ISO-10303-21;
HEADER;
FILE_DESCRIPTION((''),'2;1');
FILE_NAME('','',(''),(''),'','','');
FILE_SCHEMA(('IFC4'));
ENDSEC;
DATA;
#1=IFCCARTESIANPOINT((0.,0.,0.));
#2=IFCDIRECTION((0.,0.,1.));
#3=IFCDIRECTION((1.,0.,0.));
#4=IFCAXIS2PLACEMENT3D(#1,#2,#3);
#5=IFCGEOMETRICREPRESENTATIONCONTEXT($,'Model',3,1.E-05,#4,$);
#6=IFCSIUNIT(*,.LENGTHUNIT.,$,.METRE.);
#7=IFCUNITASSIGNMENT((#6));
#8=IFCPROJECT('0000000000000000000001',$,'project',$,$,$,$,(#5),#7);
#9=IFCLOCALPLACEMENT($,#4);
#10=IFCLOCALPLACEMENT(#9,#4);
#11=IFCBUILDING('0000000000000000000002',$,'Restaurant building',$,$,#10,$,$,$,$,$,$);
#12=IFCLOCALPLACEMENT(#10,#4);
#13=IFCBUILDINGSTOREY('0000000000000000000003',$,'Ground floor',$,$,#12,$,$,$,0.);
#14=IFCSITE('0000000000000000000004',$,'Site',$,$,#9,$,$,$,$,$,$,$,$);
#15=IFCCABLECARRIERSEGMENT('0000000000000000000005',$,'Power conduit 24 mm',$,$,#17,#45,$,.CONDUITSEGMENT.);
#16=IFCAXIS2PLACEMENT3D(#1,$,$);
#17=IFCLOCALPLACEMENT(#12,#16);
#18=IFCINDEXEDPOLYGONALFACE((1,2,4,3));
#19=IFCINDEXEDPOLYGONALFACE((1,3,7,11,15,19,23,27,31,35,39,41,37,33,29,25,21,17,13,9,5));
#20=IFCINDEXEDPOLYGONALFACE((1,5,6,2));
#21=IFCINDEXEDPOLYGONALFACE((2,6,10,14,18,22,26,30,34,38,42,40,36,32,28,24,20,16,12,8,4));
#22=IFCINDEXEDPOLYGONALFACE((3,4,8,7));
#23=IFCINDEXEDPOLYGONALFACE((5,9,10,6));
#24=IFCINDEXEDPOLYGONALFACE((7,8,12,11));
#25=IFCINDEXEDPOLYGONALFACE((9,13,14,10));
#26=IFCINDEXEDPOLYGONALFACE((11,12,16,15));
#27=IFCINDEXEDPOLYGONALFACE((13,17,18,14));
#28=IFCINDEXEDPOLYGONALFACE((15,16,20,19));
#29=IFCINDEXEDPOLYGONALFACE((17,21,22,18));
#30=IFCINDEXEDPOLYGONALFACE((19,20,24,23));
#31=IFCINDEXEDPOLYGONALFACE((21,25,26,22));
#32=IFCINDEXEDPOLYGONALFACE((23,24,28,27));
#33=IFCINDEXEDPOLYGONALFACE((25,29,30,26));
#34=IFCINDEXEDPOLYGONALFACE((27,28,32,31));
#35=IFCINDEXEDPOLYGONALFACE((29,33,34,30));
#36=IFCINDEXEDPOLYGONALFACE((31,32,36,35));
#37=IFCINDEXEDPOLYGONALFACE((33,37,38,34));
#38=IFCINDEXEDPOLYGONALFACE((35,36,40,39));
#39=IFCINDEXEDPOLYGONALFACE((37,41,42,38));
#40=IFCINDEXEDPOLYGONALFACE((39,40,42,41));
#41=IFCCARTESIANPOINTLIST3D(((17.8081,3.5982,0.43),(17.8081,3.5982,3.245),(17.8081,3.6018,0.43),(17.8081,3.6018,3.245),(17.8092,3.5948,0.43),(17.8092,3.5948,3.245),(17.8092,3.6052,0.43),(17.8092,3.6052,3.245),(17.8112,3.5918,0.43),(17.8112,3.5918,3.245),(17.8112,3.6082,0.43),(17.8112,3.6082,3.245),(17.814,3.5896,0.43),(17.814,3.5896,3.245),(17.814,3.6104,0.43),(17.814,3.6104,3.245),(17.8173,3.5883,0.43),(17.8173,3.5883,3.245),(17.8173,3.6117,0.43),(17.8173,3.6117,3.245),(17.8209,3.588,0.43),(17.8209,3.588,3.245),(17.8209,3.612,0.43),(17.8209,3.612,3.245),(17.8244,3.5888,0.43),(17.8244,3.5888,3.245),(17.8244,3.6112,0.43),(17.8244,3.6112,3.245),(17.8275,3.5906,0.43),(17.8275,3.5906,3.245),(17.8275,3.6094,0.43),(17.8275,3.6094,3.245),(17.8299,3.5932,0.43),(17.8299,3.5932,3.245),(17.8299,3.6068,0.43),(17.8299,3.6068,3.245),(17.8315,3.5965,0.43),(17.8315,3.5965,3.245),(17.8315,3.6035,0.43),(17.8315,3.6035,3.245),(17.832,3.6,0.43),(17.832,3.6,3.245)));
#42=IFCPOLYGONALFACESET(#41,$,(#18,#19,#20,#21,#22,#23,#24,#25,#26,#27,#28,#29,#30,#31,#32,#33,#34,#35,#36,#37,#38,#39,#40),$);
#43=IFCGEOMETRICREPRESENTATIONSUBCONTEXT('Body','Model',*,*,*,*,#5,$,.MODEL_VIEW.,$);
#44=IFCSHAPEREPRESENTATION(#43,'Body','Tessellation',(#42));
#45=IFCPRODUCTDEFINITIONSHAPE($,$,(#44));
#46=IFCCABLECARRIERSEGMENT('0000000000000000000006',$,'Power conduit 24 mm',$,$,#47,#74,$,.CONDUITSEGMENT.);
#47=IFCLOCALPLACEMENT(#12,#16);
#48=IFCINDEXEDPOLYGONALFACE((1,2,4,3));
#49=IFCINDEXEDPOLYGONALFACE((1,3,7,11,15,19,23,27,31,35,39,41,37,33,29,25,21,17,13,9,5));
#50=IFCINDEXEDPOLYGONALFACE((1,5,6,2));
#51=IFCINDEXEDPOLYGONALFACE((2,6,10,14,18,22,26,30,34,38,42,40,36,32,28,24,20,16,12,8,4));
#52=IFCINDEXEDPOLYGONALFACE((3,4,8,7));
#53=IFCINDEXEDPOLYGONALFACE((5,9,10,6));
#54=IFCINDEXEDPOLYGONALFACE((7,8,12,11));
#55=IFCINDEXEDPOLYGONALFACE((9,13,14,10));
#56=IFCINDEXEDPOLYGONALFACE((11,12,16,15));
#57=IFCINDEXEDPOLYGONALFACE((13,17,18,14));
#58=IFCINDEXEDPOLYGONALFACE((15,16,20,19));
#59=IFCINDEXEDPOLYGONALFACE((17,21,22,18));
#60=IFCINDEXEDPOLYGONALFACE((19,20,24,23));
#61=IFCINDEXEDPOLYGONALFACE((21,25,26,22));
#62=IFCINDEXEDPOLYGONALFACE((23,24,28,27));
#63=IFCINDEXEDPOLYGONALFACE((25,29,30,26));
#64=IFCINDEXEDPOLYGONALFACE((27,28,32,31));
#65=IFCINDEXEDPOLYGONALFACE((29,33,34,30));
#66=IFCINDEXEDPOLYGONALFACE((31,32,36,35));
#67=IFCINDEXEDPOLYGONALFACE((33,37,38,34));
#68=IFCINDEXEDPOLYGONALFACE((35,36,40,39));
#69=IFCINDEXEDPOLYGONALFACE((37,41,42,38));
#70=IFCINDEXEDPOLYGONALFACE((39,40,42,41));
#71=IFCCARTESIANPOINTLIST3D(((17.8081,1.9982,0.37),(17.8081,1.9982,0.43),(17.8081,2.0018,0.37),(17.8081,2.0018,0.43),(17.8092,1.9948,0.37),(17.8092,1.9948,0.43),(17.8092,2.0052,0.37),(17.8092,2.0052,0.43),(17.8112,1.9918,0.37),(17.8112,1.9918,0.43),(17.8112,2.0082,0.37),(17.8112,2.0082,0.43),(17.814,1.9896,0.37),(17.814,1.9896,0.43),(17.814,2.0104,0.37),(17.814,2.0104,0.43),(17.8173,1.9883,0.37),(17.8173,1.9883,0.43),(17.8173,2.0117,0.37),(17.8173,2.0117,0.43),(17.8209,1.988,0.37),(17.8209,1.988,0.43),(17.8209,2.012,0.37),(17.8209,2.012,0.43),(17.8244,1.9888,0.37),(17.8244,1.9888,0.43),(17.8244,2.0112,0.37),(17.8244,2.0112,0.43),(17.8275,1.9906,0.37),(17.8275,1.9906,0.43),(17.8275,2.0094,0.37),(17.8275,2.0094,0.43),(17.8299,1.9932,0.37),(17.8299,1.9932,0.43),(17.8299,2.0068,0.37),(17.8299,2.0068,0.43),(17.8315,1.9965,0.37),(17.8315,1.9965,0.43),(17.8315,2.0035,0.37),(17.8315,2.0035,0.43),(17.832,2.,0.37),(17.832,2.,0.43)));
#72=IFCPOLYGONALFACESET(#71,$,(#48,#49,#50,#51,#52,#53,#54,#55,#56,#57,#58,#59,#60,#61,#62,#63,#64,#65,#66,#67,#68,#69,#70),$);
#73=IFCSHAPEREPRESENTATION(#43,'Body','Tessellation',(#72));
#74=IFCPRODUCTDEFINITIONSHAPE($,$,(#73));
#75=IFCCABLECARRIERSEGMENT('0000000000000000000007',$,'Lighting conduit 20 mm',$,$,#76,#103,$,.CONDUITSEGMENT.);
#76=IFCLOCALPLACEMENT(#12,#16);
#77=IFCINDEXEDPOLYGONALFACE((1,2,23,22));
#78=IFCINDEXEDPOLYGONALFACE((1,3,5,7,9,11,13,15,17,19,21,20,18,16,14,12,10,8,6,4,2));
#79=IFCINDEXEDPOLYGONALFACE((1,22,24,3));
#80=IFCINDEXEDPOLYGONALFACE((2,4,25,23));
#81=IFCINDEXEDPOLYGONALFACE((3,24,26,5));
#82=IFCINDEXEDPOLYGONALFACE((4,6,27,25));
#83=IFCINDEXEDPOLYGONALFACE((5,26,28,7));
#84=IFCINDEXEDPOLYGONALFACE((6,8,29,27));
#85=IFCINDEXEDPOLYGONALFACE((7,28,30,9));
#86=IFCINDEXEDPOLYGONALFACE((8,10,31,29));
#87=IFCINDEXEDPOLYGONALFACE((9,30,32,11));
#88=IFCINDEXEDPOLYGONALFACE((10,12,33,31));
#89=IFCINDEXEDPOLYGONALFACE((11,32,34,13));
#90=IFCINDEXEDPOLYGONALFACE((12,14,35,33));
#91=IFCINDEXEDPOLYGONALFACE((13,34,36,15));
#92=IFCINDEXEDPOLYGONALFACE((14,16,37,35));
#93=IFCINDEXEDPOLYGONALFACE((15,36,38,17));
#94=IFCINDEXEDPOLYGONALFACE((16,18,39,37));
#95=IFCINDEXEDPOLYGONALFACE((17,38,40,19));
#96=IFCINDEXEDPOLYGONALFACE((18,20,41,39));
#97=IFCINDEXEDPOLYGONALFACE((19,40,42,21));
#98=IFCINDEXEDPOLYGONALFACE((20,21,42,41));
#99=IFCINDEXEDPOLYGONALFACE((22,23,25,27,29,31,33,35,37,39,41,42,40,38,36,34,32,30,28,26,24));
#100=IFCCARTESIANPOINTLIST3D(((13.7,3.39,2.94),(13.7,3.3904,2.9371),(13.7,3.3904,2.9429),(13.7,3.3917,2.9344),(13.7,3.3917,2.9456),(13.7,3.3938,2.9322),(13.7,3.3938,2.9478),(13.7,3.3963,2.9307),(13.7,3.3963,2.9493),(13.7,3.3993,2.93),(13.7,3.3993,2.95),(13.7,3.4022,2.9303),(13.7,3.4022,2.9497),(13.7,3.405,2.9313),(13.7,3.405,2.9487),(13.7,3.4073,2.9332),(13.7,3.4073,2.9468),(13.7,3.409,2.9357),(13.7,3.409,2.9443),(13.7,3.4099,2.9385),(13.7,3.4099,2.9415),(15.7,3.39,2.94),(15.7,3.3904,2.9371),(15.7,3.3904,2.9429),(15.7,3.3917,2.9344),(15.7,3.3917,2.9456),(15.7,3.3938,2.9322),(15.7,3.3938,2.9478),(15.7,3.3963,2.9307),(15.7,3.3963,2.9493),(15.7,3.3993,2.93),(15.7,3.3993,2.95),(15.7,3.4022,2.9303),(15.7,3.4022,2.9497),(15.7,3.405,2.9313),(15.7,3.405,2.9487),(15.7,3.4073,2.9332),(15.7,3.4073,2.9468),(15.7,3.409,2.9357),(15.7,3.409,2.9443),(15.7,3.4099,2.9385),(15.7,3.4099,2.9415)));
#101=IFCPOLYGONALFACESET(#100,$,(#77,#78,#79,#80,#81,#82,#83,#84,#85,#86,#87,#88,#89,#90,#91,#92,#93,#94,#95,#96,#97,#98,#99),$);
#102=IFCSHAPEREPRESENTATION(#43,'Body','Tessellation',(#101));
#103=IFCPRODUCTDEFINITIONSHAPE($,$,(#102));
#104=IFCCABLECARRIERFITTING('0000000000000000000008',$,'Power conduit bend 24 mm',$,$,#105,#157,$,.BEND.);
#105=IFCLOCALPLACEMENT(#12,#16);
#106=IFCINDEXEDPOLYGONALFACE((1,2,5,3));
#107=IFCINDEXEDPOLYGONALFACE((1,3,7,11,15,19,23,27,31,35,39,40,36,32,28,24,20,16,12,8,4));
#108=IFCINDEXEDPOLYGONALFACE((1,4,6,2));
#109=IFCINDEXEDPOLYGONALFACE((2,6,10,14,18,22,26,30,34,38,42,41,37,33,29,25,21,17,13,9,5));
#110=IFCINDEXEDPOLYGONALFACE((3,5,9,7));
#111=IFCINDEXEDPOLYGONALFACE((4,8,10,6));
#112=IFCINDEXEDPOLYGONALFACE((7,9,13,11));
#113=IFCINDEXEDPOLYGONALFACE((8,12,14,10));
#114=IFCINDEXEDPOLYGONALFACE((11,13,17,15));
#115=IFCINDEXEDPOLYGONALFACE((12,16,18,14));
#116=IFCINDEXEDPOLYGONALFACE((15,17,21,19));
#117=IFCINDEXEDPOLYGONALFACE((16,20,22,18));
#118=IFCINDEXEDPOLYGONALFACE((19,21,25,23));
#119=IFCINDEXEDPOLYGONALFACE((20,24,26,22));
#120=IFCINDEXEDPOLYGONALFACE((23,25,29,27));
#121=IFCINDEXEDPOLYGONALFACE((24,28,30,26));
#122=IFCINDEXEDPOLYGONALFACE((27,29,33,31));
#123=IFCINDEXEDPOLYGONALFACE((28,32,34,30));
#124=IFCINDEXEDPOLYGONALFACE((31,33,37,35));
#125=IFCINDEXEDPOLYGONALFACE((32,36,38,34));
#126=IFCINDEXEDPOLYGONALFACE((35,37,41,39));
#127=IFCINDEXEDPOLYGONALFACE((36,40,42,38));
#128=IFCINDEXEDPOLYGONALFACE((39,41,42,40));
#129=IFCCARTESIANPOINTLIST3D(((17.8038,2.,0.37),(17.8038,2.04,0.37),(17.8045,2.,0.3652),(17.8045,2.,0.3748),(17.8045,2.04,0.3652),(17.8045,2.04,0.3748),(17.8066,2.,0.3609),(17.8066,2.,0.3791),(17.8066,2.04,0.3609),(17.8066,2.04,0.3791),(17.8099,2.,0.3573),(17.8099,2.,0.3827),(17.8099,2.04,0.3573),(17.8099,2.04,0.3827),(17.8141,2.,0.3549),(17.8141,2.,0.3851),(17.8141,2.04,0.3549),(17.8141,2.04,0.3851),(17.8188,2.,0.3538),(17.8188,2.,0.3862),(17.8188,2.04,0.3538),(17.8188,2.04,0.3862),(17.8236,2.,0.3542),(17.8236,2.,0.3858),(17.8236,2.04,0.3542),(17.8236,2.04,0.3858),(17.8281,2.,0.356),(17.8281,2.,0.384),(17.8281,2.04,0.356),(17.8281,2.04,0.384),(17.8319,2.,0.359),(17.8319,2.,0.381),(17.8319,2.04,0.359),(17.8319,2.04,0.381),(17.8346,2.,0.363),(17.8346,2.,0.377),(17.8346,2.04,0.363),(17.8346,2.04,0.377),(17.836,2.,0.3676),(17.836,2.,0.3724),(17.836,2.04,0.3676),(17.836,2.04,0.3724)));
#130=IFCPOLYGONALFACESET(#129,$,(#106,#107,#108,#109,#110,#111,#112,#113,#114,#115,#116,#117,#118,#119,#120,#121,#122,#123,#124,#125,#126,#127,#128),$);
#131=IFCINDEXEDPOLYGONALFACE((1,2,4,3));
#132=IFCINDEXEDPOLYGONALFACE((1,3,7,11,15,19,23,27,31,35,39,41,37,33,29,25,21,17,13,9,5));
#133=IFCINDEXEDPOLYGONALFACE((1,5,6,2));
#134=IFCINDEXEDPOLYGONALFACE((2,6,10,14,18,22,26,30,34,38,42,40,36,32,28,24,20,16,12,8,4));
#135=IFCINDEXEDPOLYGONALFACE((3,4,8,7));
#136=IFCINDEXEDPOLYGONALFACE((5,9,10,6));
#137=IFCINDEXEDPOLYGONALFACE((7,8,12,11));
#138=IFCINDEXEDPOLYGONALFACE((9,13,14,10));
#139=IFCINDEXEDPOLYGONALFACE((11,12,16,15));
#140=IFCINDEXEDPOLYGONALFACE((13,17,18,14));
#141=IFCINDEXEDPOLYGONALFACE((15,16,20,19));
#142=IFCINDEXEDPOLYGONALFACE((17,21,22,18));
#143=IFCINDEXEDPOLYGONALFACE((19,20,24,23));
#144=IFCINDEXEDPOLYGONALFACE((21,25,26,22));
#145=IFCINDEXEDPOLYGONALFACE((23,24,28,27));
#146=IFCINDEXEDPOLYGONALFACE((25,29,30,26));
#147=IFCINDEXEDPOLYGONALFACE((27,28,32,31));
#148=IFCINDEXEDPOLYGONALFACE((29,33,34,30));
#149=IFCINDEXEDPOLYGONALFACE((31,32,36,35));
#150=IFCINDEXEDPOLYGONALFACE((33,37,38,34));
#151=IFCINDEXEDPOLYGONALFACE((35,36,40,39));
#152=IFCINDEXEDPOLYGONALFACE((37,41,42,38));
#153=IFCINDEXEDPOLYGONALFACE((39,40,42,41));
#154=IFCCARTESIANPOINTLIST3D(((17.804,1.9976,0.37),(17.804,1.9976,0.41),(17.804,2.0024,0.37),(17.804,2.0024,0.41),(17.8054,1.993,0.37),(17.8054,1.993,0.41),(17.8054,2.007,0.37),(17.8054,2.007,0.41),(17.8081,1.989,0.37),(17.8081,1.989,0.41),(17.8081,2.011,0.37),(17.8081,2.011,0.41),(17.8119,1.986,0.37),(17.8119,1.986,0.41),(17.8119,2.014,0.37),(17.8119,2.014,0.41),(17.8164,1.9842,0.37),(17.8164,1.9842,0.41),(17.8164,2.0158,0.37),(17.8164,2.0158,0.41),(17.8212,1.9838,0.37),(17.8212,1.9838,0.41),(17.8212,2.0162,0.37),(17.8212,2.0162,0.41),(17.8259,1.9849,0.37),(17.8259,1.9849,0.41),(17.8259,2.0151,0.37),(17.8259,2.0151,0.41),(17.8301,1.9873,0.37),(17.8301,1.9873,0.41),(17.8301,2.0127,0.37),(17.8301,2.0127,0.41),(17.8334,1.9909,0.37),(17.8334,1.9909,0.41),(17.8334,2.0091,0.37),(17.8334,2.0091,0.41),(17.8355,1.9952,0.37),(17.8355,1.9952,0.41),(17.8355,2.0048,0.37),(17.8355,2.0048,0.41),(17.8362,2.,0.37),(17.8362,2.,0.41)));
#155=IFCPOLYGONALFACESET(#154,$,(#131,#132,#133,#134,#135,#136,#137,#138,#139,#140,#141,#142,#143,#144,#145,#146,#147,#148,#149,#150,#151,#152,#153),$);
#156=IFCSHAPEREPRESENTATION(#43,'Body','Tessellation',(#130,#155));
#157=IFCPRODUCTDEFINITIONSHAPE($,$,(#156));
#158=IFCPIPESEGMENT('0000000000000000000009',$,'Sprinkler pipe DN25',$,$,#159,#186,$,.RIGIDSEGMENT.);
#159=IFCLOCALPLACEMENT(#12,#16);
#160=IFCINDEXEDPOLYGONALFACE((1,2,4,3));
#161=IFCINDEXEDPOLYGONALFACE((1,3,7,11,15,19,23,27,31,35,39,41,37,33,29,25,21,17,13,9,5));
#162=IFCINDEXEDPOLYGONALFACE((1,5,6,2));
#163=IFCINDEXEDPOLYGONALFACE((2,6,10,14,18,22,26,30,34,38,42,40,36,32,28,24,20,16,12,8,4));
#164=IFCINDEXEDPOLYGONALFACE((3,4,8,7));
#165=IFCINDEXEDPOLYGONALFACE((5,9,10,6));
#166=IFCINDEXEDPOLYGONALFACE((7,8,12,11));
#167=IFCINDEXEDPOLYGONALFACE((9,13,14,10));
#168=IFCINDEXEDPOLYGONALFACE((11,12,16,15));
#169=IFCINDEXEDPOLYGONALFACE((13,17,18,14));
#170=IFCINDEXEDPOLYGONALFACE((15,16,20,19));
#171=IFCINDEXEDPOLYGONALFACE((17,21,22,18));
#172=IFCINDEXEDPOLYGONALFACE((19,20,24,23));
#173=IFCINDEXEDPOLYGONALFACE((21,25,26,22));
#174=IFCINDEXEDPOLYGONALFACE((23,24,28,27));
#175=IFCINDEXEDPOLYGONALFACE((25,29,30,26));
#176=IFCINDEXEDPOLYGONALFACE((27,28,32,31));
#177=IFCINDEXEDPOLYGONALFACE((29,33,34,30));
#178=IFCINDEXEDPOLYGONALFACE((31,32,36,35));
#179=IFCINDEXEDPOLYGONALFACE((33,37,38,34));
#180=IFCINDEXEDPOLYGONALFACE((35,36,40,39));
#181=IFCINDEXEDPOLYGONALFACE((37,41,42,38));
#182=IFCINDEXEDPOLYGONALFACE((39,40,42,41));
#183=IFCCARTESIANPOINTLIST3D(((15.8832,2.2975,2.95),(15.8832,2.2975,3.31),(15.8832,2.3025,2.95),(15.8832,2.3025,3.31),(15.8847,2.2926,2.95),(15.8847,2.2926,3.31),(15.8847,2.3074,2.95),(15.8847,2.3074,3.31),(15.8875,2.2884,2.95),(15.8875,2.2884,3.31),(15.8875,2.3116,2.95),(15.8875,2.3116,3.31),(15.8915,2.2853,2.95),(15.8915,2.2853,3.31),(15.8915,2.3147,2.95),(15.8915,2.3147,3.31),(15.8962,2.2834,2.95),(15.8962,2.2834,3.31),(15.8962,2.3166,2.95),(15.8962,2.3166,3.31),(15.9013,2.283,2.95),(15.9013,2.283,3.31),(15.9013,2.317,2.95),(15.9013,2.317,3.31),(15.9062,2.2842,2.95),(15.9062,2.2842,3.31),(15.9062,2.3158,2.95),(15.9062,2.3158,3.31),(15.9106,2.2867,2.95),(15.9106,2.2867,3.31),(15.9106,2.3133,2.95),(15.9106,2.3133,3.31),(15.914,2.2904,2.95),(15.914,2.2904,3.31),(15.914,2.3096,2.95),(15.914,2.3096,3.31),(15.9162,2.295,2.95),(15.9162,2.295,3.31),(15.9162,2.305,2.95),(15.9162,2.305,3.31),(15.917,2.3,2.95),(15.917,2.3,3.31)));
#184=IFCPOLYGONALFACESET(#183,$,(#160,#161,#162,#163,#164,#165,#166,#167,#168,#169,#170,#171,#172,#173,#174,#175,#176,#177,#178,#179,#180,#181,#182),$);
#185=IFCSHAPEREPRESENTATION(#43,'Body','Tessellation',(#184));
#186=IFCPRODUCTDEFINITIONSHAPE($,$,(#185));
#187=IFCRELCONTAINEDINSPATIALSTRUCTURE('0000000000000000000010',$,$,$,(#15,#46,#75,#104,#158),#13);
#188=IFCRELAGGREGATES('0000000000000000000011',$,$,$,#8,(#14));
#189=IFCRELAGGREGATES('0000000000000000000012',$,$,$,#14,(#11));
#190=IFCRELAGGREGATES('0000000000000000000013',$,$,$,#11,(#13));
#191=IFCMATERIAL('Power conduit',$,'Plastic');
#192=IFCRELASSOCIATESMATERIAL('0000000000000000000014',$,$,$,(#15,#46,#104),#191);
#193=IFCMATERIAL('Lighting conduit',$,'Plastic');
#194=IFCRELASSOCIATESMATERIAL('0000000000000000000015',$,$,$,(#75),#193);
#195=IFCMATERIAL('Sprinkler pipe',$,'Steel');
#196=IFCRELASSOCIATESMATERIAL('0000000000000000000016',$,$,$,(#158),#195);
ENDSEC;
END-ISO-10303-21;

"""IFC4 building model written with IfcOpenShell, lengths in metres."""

from ifc_helpers import new_model, si_unit, frame, origin, origin_with_axes, origin_2d, place, context, subcontext, project, spatial, circle, extrude, material, element, save


model = new_model("IFC4")

# Units and contexts
model_context = context("Model", 3, precision=1e-05, world=origin_with_axes())
body_context = subcontext(model_context, "Body", "Model", "MODEL_VIEW")
ifc_project = project(units=[si_unit("LENGTHUNIT", "METRE")], contexts=[model_context])

# Site, building, storey
site_placement = place(None, origin_with_axes())
site = spatial("IfcSite", under=ifc_project, at=site_placement, Name="Site")
building_placement = place(site_placement, origin_with_axes())
building = spatial("IfcBuilding", under=site, at=building_placement, Name="Restaurant building")
storey_placement = place(building_placement, origin_with_axes())
storey = spatial("IfcBuildingStorey", under=building, at=storey_placement, Name="Ground floor", Elevation=0.0)

# Cable carrier segments
ifc_material_1 = material(Name="Power conduit", Category="Plastic")
cable_carrier_segment_1_placement = place(storey_placement, frame((17.82, 3.6, 3.245)))
element("IfcCableCarrierSegment", 1, at=cable_carrier_segment_1_placement, inside=storey, material=ifc_material_1, Name="Power conduit 24 mm", PredefinedType="CONDUITSEGMENT", context=body_context, shape_type="SweptSolid", body=[
    extrude(circle(Radius=0.012, at=origin_2d()), frame((0.0, 0.0, 0.0), z_axis=(0.0, 0.0, -1.0), x_axis=(1.0, 0.0, 0.0)), (0.0, 0.0, 1.0), 2.815),
])
cable_carrier_segment_2_placement = place(storey_placement, frame((17.82, 2.0, 0.37)))
element("IfcCableCarrierSegment", 2, at=cable_carrier_segment_2_placement, inside=storey, material=ifc_material_1, Name="Power conduit 24 mm", PredefinedType="CONDUITSEGMENT", context=body_context, shape_type="SweptSolid", body=[
    extrude(circle(Radius=0.012, at=origin_2d()), origin(), (0.0, 0.0, 1.0), 0.06),
])
ifc_material_2 = material(Name="Lighting conduit", Category="Plastic")
cable_carrier_segment_3_placement = place(storey_placement, frame((15.7, 3.4, 2.94)))
element("IfcCableCarrierSegment", 3, at=cable_carrier_segment_3_placement, inside=storey, material=ifc_material_2, Name="Lighting conduit 20 mm", PredefinedType="CONDUITSEGMENT", context=body_context, shape_type="SweptSolid", body=[
    extrude(circle(Radius=0.01, at=origin_2d()), frame((0.0, 0.0, 0.0), z_axis=(-1.0, 0.0, 0.0), x_axis=(0.0, -1.0, 0.0)), (0.0, 0.0, 1.0), 2.0),
])

# Cable carrier fitting
cable_carrier_fitting_1_placement = place(storey_placement, frame((17.82, 2.0, 0.37)))
element("IfcCableCarrierFitting", 4, at=cable_carrier_fitting_1_placement, inside=storey, material=ifc_material_1, Name="Power conduit bend 24 mm", PredefinedType="BEND", context=body_context, shape_type="SweptSolid", body=[
    extrude(circle(Radius=0.0162, at=origin_2d()), frame((0.0, 0.0, 0.0), z_axis=(0.0, 1.0, 0.0), x_axis=(-1.0, 0.0, 0.0)), (0.0, 0.0, 1.0), 0.04),
    extrude(circle(Radius=0.0162, at=origin_2d()), origin(), (0.0, 0.0, 1.0), 0.04),
])

# Pipe segment
ifc_material_3 = material(Name="Sprinkler pipe", Category="Steel")
pipe_segment_placement = place(storey_placement, frame((15.9, 2.3, 3.31)))
element("IfcPipeSegment", 5, at=pipe_segment_placement, inside=storey, material=ifc_material_3, Name="Sprinkler pipe DN25", PredefinedType="RIGIDSEGMENT", context=body_context, shape_type="SweptSolid", body=[
    extrude(circle(Radius=0.017, at=origin_2d()), frame((0.0, 0.0, 0.0), z_axis=(0.0, 0.0, -1.0), x_axis=(1.0, 0.0, 0.0)), (0.0, 0.0, 1.0), 0.36),
])

save(model, "model.ifc")
